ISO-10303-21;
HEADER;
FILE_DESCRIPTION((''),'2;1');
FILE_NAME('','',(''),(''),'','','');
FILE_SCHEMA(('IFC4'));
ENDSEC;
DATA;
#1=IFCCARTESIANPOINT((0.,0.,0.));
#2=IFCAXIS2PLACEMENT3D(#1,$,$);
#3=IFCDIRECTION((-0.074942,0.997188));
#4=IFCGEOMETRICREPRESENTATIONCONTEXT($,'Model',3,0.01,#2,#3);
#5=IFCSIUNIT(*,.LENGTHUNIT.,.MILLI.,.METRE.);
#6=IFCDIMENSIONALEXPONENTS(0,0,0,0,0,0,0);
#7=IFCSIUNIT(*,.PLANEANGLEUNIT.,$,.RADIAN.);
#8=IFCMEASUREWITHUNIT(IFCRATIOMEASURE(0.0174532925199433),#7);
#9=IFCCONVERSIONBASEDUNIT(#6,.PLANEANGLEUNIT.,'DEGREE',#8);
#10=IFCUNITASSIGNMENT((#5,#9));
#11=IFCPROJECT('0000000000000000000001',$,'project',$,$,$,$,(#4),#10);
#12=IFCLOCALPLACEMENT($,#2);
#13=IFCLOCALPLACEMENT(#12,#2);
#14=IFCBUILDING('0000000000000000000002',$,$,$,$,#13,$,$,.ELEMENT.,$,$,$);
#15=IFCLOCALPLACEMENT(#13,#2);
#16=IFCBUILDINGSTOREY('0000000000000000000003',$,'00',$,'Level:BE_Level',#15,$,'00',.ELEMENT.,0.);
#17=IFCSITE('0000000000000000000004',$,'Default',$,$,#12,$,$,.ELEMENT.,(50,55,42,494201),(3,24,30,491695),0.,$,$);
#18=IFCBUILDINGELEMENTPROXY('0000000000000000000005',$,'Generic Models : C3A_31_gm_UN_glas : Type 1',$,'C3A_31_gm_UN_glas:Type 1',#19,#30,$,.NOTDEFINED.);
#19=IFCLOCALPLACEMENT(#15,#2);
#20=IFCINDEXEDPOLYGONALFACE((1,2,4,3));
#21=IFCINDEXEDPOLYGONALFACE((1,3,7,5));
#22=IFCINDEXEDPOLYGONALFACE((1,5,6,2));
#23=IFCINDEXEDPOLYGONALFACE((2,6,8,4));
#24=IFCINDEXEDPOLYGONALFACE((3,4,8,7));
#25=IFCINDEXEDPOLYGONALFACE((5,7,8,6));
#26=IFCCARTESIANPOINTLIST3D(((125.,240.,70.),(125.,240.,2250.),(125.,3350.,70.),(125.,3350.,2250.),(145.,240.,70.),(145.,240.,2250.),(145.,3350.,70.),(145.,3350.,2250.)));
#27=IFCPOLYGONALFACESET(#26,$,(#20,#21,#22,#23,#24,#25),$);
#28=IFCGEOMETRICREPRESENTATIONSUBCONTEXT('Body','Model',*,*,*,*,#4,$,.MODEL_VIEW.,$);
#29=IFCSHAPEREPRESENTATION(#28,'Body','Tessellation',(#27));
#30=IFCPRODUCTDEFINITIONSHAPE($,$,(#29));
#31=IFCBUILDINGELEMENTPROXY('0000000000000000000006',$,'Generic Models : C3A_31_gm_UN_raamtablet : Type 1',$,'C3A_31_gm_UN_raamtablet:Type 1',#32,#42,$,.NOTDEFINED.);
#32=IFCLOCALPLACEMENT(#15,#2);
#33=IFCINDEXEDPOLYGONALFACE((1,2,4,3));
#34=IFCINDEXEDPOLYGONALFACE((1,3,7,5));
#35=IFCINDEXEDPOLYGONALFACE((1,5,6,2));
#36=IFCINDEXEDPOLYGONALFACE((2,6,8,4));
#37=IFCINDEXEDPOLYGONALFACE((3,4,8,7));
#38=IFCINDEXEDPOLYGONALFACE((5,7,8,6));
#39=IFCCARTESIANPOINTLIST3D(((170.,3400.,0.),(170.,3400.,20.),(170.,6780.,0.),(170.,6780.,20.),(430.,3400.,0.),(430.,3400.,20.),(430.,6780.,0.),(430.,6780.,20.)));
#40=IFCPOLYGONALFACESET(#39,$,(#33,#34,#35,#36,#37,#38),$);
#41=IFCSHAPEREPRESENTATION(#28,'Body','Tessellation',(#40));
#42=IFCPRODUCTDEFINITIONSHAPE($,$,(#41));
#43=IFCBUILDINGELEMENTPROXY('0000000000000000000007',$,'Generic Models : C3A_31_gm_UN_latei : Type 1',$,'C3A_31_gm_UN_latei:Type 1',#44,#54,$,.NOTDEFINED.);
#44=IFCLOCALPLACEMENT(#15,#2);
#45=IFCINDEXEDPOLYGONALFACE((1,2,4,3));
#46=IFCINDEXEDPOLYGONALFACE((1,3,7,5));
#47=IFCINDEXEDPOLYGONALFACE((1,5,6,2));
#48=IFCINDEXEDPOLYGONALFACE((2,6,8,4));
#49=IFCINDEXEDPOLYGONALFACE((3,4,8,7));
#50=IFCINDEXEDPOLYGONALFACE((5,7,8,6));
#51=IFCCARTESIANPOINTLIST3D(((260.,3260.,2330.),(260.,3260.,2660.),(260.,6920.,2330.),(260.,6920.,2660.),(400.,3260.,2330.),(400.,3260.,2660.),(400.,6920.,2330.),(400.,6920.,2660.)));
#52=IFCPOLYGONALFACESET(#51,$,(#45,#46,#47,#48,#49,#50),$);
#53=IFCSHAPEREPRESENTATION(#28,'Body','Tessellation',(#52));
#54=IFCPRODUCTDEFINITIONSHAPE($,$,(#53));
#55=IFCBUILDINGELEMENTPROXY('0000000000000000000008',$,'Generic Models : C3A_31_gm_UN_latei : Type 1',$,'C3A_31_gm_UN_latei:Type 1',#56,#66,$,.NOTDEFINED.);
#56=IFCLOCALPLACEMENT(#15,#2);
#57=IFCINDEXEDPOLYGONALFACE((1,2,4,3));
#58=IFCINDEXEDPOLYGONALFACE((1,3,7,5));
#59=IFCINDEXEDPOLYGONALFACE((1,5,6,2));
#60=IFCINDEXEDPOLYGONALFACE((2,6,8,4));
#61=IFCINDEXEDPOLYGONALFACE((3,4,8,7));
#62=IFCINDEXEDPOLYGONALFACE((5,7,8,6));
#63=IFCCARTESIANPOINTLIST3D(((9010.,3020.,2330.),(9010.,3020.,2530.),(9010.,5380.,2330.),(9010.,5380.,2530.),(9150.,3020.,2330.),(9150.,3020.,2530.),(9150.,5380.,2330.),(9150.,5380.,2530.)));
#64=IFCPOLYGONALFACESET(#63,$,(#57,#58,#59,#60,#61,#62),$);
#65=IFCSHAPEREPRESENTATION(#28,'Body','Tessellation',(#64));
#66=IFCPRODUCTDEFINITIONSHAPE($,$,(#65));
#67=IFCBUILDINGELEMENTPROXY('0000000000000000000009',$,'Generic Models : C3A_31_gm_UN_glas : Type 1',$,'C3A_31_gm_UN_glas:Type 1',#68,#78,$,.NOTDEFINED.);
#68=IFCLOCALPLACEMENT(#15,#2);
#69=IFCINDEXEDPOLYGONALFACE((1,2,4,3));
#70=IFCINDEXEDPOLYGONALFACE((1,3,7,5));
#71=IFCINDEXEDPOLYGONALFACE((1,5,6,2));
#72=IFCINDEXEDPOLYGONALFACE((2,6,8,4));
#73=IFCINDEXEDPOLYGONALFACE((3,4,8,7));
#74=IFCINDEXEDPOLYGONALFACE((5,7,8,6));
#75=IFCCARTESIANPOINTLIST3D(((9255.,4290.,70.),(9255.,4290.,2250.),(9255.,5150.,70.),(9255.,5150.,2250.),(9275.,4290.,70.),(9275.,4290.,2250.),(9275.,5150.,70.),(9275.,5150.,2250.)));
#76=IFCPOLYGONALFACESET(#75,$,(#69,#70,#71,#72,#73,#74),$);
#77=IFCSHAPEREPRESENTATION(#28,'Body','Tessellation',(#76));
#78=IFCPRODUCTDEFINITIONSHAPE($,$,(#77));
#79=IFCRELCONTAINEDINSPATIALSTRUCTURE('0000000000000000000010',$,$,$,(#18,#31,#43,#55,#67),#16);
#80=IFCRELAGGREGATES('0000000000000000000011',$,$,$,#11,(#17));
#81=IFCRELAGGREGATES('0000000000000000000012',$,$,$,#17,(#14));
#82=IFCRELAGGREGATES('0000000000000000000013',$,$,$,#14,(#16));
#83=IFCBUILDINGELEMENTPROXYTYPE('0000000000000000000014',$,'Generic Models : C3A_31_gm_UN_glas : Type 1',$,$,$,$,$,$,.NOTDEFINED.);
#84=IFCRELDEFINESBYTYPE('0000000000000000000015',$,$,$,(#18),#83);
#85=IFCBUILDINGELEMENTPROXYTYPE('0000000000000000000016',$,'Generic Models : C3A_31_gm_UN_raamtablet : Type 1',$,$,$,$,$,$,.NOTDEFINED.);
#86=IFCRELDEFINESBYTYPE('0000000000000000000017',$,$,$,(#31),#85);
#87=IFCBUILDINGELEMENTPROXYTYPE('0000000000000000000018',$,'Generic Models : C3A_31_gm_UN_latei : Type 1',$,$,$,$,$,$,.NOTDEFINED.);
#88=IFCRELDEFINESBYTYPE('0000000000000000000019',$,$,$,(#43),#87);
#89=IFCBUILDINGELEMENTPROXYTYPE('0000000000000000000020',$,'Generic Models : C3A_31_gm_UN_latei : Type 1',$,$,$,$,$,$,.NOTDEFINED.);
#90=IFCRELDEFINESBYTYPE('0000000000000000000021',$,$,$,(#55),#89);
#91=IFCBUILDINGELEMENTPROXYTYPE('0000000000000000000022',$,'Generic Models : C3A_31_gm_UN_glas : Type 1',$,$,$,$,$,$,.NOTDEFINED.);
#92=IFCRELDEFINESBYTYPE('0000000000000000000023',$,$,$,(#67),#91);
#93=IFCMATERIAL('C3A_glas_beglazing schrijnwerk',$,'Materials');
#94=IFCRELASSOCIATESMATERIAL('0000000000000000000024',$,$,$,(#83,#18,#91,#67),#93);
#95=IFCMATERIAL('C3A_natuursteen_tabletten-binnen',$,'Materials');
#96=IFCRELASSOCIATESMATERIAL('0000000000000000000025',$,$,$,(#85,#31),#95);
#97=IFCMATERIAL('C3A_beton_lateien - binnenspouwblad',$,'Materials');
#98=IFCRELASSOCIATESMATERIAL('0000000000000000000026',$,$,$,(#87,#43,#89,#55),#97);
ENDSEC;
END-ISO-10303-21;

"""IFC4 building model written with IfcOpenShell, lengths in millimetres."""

from ifc_helpers import new_model, entity, si_unit, converted_unit, direction, frame, frame_2d, origin, origin_2d_with_axis, place, context, subcontext, project, spatial, rectangle, extrude, source, transform, mapped, material, type_object, type_shapes, element, save


model = new_model("IFC4")

# Units and contexts
model_context = context("Model", 3, precision=0.01, world=origin(), true_north=direction((-0.074942, 0.997188)))
body_context = subcontext(model_context, "Body", "Model", "MODEL_VIEW")
ifc_project = project(units=[si_unit("LENGTHUNIT", "METRE", prefix="MILLI"), converted_unit("PLANEANGLEUNIT", "DEGREE", entity("IfcRatioMeasure", 0.0174532925199433), si_unit("PLANEANGLEUNIT", "RADIAN"), dimensions=[0, 0, 0, 0, 0, 0, 0])], contexts=[model_context])

# Site, building, storey
site_placement = place(None, origin())
site = spatial("IfcSite", under=ifc_project, at=site_placement, Name="Default", CompositionType="ELEMENT", RefLatitude=(50, 55, 42, 494201), RefLongitude=(3, 24, 30, 491695), RefElevation=0.0)
building_placement = place(site_placement, origin())
building = spatial("IfcBuilding", under=site, at=building_placement, CompositionType="ELEMENT")
storey_placement = place(building_placement, frame((0.0, 0.0, 0.0)))
storey = spatial("IfcBuildingStorey", under=building, at=storey_placement, Name="00", ObjectType="Level:BE_Level", LongName="00", CompositionType="ELEMENT", Elevation=0.0)

# Building element proxies
ifc_material_1 = material(Name="C3A_beton_lateien - binnenspouwblad", Category="Materials")
ifc_material_2 = material(Name="C3A_glas_beglazing schrijnwerk", Category="Materials")
ifc_material_3 = material(Name="C3A_natuursteen_tabletten-binnen", Category="Materials")
building_element_proxy_type_1 = type_object("IfcBuildingElementProxyType", Name="Generic Models : C3A_31_gm_UN_glas : Type 1", PredefinedType="NOTDEFINED", material=ifc_material_2)
shared_shape_1 = source(origin(), body_context, "Body", "SweptSolid", [
    extrude(rectangle(XDim=3110.0, YDim=20.0, at=origin_2d_with_axis()), frame((1555.0, 10.0, 0.0), z_axis=(0.0, 0.0, 1.0), x_axis=(-1.0, 0.0, 0.0)), (0.0, 0.0, 1.0), 2180.0),
])
type_shapes(building_element_proxy_type_1, [shared_shape_1])
proxy_1_placement = place(storey_placement, frame((145.0, 240.0, 70.0), z_axis=(0.0, 0.0, 1.0), x_axis=(0.0, 1.0, 0.0)))
element("IfcBuildingElementProxy", 1, at=proxy_1_placement, inside=storey, type_object=building_element_proxy_type_1, material=ifc_material_2, Name="Generic Models : C3A_31_gm_UN_glas : Type 1", ObjectType="C3A_31_gm_UN_glas:Type 1", PredefinedType="NOTDEFINED", context=body_context, shape_type="MappedRepresentation", body=[
    mapped(shared_shape_1, transform((0.0, 0.0, 0.0), scale=1.0)),
])
building_element_proxy_type_2 = type_object("IfcBuildingElementProxyType", Name="Generic Models : C3A_31_gm_UN_raamtablet : Type 1", PredefinedType="NOTDEFINED", material=ifc_material_3)
shared_shape_2 = source(origin(), body_context, "Body", "SweptSolid", [
    extrude(rectangle(XDim=260.0, YDim=3380.0, at=frame_2d((0.0, 0.0), x_axis=(1.0, 0.0))), frame((0.0, -130.0, 0.0), z_axis=(0.0, 0.0, 1.0), x_axis=(0.0, 1.0, 0.0)), (0.0, 0.0, 1.0), 20.0),
])
type_shapes(building_element_proxy_type_2, [shared_shape_2])
proxy_2_placement = place(storey_placement, frame((430.0, 5090.0, 0.0), z_axis=(0.0, 0.0, 1.0), x_axis=(0.0, -1.0, 0.0)))
element("IfcBuildingElementProxy", 2, at=proxy_2_placement, inside=storey, type_object=building_element_proxy_type_2, material=ifc_material_3, Name="Generic Models : C3A_31_gm_UN_raamtablet : Type 1", ObjectType="C3A_31_gm_UN_raamtablet:Type 1", PredefinedType="NOTDEFINED", context=body_context, shape_type="MappedRepresentation", body=[
    mapped(shared_shape_2, transform((0.0, 0.0, 0.0), scale=1.0)),
])
building_element_proxy_type_3 = type_object("IfcBuildingElementProxyType", Name="Generic Models : C3A_31_gm_UN_latei : Type 1", PredefinedType="NOTDEFINED", material=ifc_material_1)
shared_shape_3 = source(origin(), body_context, "Body", "SweptSolid", [
    extrude(rectangle(XDim=140.0, YDim=3660.0, at=frame_2d((0.0, 0.0), x_axis=(1.0, 0.0))), frame((0.0, -70.0, 0.0), z_axis=(0.0, 0.0, 1.0), x_axis=(0.0, 1.0, 0.0)), (0.0, 0.0, 1.0), 330.0),
])
type_shapes(building_element_proxy_type_3, [shared_shape_3])
proxy_3_placement = place(storey_placement, frame((400.0, 5090.0, 2330.0), z_axis=(0.0, 0.0, 1.0), x_axis=(0.0, -1.0, 0.0)))
element("IfcBuildingElementProxy", 3, at=proxy_3_placement, inside=storey, type_object=building_element_proxy_type_3, material=ifc_material_1, Name="Generic Models : C3A_31_gm_UN_latei : Type 1", ObjectType="C3A_31_gm_UN_latei:Type 1", PredefinedType="NOTDEFINED", context=body_context, shape_type="MappedRepresentation", body=[
    mapped(shared_shape_3, transform((0.0, 0.0, 0.0), scale=1.0)),
])
building_element_proxy_type_4 = type_object("IfcBuildingElementProxyType", Name="Generic Models : C3A_31_gm_UN_latei : Type 1", PredefinedType="NOTDEFINED", material=ifc_material_1)
shared_shape_4 = source(origin(), body_context, "Body", "SweptSolid", [
    extrude(rectangle(XDim=2360.0, YDim=140.0, at=origin_2d_with_axis()), frame((0.0, 70.0, 0.0), z_axis=(0.0, 0.0, 1.0), x_axis=(-1.0, 0.0, 0.0)), (0.0, 0.0, 1.0), 200.0),
])
type_shapes(building_element_proxy_type_4, [shared_shape_4])
proxy_4_placement = place(storey_placement, frame((9010.0, 4200.0, 2330.0), z_axis=(0.0, 0.0, 1.0), x_axis=(0.0, -1.0, 0.0)))
element("IfcBuildingElementProxy", 4, at=proxy_4_placement, inside=storey, type_object=building_element_proxy_type_4, material=ifc_material_1, Name="Generic Models : C3A_31_gm_UN_latei : Type 1", ObjectType="C3A_31_gm_UN_latei:Type 1", PredefinedType="NOTDEFINED", context=body_context, shape_type="MappedRepresentation", body=[
    mapped(shared_shape_4, transform((0.0, 0.0, 0.0), scale=1.0)),
])
building_element_proxy_type_5 = type_object("IfcBuildingElementProxyType", Name="Generic Models : C3A_31_gm_UN_glas : Type 1", PredefinedType="NOTDEFINED", material=ifc_material_2)
shared_shape_5 = source(origin(), body_context, "Body", "SweptSolid", [
    extrude(rectangle(XDim=860.0, YDim=20.0, at=origin_2d_with_axis()), frame((430.0, 10.0, 0.0), z_axis=(0.0, 0.0, 1.0), x_axis=(-1.0, 0.0, 0.0)), (0.0, 0.0, 1.0), 2180.0),
])
type_shapes(building_element_proxy_type_5, [shared_shape_5])
proxy_5_placement = place(storey_placement, frame((9255.0, 5150.0, 70.0), z_axis=(0.0, 0.0, 1.0), x_axis=(0.0, -1.0, 0.0)))
element("IfcBuildingElementProxy", 5, at=proxy_5_placement, inside=storey, type_object=building_element_proxy_type_5, material=ifc_material_2, Name="Generic Models : C3A_31_gm_UN_glas : Type 1", ObjectType="C3A_31_gm_UN_glas:Type 1", PredefinedType="NOTDEFINED", context=body_context, shape_type="MappedRepresentation", body=[
    mapped(shared_shape_5, transform((0.0, 0.0, 0.0), scale=1.0)),
])

save(model, "model.ifc")
